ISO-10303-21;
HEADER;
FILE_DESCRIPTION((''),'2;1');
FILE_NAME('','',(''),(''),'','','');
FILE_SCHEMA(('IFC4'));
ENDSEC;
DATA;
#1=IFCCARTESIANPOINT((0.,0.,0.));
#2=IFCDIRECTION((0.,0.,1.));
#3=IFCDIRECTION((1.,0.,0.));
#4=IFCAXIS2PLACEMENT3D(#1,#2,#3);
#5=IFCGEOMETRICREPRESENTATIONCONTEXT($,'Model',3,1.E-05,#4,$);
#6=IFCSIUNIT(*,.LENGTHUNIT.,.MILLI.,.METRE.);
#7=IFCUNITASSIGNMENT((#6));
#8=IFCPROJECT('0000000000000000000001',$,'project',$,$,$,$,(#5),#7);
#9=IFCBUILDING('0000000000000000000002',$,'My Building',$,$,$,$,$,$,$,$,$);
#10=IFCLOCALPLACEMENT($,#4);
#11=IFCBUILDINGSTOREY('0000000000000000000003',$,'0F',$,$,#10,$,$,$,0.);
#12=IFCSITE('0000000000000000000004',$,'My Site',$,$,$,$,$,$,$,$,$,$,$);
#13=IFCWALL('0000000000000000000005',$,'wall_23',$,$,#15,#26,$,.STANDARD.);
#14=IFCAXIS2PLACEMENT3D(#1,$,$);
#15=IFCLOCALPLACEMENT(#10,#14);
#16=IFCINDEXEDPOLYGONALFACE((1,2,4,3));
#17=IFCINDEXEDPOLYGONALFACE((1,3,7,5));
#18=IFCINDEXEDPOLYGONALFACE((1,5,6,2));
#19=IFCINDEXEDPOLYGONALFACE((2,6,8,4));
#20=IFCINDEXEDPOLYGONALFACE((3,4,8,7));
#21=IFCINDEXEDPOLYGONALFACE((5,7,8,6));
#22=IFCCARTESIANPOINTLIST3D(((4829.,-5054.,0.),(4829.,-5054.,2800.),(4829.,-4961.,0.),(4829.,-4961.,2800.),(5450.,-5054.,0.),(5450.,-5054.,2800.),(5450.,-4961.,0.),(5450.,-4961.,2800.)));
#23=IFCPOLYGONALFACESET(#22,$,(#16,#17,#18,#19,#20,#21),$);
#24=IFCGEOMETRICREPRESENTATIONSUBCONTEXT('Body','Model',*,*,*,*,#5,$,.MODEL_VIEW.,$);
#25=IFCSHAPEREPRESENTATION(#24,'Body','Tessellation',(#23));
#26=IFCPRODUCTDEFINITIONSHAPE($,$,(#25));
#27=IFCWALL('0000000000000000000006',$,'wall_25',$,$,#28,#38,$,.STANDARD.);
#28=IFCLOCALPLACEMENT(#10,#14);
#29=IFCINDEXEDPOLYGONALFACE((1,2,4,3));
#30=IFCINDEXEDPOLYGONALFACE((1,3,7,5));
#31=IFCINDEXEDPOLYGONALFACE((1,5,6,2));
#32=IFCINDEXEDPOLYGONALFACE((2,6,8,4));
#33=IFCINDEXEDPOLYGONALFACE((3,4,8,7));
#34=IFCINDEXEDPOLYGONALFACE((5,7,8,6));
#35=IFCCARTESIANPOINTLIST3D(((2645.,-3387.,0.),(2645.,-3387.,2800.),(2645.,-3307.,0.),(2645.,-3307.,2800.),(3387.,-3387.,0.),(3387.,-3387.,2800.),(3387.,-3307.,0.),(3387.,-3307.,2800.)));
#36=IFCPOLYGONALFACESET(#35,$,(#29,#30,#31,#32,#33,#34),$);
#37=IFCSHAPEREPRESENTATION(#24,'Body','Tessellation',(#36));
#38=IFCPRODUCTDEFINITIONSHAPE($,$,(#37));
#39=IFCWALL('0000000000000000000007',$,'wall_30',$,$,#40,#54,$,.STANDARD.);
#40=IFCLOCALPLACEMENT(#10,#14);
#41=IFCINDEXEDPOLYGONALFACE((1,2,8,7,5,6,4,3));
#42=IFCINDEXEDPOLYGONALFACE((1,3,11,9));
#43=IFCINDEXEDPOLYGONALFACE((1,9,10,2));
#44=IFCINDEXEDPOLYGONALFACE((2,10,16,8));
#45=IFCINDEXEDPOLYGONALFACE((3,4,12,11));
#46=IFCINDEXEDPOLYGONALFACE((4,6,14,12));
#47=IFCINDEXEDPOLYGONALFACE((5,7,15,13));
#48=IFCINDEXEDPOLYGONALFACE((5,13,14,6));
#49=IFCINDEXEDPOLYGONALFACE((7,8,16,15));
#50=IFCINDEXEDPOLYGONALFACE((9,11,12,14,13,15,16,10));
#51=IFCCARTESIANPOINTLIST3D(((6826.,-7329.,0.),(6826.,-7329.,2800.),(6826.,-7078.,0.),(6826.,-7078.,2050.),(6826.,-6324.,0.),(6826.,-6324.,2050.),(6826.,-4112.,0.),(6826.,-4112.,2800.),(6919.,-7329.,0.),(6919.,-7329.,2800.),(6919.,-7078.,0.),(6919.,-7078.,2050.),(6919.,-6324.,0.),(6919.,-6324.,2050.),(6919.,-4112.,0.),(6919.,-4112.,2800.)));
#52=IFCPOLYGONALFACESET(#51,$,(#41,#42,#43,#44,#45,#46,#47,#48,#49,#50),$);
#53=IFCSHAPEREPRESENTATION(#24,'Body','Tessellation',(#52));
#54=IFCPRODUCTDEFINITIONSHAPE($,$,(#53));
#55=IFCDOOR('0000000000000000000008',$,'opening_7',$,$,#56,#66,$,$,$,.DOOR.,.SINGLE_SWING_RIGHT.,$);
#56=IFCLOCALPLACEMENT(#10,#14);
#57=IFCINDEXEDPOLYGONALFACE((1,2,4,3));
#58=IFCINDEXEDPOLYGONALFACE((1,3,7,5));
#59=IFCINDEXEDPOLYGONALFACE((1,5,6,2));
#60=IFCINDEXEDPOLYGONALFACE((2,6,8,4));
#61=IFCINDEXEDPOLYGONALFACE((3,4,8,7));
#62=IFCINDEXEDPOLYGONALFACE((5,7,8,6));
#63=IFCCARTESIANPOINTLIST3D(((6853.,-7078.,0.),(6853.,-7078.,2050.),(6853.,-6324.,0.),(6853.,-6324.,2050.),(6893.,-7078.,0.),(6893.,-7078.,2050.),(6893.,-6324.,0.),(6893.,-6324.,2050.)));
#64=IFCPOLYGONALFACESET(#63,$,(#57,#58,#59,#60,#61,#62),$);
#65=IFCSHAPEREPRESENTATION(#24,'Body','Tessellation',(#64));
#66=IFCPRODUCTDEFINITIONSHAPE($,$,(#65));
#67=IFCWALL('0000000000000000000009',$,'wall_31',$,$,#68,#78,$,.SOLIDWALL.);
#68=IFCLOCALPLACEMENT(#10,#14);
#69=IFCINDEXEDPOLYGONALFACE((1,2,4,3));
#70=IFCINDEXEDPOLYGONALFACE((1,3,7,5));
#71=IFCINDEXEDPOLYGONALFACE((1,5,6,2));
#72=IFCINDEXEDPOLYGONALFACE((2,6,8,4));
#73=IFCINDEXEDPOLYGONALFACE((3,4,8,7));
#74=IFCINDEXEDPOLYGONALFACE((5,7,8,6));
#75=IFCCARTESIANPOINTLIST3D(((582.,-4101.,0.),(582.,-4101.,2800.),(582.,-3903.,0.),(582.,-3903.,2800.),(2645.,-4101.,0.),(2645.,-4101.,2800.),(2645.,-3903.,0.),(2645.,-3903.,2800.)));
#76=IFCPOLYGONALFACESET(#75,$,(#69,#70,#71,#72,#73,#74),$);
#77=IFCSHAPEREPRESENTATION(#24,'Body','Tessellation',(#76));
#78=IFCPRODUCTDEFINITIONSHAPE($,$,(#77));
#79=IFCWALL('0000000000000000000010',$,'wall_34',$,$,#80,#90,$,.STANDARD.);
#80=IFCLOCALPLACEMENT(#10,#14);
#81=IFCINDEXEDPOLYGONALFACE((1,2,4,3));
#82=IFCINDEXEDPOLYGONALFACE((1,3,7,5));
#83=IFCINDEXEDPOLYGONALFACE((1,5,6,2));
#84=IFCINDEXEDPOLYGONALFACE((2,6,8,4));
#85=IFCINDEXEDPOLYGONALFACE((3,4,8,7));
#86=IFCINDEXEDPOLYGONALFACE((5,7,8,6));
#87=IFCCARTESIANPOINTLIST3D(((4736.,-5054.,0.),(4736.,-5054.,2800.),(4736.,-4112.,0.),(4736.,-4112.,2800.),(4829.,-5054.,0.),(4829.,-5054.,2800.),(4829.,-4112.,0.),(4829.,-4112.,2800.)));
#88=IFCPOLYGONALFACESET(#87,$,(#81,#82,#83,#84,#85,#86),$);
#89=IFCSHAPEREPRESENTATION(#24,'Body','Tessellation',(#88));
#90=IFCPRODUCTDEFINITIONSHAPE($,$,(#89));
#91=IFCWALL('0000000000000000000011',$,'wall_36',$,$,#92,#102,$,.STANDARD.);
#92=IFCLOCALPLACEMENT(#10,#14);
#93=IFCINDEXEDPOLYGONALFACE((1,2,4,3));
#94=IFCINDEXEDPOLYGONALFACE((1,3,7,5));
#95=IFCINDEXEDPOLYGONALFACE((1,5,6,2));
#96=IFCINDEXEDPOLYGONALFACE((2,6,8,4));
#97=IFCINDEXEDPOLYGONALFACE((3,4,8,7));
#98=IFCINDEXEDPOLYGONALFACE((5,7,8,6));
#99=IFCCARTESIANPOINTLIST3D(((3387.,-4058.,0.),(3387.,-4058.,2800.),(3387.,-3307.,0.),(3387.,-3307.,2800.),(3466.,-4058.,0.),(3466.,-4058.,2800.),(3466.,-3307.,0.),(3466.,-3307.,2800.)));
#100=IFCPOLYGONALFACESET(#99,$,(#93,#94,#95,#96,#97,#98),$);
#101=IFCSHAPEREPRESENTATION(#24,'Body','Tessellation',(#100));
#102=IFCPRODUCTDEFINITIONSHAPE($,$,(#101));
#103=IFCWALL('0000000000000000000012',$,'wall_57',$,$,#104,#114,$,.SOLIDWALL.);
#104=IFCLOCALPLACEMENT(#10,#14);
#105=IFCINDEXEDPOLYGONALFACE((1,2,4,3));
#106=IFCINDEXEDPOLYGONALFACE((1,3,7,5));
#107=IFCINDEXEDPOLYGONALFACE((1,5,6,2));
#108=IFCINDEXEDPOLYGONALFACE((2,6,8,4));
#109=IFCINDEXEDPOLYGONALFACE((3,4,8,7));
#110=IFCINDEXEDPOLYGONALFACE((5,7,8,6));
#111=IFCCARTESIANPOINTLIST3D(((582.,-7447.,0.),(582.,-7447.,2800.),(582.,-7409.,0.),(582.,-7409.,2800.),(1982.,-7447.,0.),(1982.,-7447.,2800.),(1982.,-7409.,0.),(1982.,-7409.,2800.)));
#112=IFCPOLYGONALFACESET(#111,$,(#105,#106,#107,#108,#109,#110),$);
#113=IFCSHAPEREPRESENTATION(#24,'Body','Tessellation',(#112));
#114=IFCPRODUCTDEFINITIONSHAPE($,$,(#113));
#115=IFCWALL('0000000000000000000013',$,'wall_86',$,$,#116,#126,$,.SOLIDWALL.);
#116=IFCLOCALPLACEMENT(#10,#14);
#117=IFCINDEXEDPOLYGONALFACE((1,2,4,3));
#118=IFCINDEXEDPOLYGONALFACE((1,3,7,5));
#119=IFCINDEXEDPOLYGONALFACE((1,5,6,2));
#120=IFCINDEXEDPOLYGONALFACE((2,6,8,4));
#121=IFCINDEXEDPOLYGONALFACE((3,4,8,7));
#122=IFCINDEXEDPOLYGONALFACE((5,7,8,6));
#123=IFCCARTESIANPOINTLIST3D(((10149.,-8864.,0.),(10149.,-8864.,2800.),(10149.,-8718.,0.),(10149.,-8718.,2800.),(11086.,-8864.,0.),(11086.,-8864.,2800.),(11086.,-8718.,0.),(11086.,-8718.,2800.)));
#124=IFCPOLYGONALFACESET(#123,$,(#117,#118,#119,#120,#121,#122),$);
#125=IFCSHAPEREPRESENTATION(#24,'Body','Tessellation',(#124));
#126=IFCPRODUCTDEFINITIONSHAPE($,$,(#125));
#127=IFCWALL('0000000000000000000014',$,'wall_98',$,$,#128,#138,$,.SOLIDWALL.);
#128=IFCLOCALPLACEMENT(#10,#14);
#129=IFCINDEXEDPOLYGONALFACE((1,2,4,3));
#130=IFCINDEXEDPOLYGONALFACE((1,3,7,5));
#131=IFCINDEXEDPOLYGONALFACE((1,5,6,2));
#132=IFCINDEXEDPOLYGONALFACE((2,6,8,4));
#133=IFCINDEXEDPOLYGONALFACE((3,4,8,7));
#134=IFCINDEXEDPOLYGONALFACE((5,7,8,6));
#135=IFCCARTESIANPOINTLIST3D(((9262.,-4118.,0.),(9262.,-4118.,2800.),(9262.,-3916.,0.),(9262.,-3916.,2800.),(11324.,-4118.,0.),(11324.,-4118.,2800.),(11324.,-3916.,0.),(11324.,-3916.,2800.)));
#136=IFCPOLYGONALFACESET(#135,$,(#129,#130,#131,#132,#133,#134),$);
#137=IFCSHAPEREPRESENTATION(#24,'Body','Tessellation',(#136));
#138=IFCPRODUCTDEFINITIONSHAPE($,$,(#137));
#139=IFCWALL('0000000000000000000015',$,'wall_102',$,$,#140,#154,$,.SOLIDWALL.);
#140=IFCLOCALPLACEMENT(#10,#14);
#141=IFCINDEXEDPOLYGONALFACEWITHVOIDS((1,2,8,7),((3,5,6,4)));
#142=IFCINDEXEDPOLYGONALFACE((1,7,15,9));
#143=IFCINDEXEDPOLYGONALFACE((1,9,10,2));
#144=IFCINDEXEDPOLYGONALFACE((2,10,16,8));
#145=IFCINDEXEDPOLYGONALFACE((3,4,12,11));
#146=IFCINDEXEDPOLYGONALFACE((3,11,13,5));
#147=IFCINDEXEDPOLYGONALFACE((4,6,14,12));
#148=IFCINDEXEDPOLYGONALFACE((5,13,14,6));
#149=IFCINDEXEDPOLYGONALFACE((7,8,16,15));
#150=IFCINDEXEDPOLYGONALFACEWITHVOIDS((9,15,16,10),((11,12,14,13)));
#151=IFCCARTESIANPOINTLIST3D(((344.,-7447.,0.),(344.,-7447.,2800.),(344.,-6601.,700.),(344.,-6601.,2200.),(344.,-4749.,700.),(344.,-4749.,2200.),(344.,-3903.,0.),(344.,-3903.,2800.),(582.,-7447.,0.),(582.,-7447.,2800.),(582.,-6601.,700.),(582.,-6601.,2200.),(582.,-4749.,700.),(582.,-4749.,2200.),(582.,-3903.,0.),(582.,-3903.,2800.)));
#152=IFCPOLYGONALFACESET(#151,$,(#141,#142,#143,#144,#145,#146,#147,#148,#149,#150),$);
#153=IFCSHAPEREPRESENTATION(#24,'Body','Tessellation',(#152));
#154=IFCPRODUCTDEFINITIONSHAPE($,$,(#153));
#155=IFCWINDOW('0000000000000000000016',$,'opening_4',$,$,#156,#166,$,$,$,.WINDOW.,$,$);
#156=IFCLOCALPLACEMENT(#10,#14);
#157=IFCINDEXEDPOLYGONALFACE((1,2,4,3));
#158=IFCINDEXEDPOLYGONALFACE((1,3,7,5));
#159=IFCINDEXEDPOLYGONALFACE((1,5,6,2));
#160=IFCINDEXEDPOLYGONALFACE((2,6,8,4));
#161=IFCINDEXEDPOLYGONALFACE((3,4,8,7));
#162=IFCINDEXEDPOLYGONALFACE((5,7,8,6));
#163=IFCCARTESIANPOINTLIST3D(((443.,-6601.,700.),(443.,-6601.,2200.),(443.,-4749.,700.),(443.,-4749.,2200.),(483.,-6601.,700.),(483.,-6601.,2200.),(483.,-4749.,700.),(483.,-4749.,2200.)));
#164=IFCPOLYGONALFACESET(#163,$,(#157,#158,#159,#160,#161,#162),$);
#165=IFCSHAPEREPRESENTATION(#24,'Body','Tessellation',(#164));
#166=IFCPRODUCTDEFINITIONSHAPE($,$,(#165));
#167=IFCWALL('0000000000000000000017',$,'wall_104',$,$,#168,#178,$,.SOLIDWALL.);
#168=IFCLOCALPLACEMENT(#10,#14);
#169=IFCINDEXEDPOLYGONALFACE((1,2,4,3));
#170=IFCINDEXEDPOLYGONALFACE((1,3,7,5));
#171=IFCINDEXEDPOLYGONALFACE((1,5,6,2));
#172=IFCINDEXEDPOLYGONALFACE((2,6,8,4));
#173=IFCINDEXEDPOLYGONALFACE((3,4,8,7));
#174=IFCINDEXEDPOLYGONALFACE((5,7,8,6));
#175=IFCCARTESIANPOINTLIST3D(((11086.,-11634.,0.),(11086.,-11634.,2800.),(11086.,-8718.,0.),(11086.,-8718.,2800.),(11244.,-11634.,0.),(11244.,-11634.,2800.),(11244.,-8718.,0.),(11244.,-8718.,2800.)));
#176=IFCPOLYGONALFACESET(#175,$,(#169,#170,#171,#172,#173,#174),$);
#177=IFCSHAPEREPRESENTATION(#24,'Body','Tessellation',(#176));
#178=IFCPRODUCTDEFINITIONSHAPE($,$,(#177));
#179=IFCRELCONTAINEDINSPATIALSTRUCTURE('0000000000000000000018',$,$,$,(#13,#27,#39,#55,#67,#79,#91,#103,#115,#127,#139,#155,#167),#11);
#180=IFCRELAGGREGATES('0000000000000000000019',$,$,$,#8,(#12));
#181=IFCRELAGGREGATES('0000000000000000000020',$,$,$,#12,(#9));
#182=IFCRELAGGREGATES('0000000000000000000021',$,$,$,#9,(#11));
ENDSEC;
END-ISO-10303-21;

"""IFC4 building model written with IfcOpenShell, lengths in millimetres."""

from ifc_helpers import new_model, si_unit, frame, origin_with_axes, place, context, subcontext, project, spatial, indexed_curve, outline, extrude, element, fill, save


model = new_model("IFC4")

# Units and contexts
model_context = context("Model", 3, precision=1e-05, world=origin_with_axes())
body_context = subcontext(model_context, "Body", "Model", "MODEL_VIEW")
ifc_project = project(units=[si_unit("LENGTHUNIT", "METRE", prefix="MILLI")], contexts=[model_context])

# Site, building, storey
site = spatial("IfcSite", under=ifc_project, Name="My Site")
building = spatial("IfcBuilding", under=site, Name="My Building")
storey_placement = place(None, origin_with_axes())
storey = spatial("IfcBuildingStorey", under=building, at=storey_placement, Name="0F", Elevation=0.0)

# Walls
wall_1_placement = place(storey_placement, origin_with_axes())
element("IfcWall", 1, at=wall_1_placement, inside=storey, Name="wall_23", PredefinedType="STANDARD", context=body_context, shape_type="SweptSolid", body=[
    extrude(outline(indexed_curve([(4829.0, -5054.0), (5450.0, -5054.0), (5450.0, -4961.0), (4829.0, -4961.0), (4829.0, -5054.0)])), None, (0.0, 0.0, 1.0), 2800.0),
])
wall_2_placement = place(storey_placement, origin_with_axes())
element("IfcWall", 2, at=wall_2_placement, inside=storey, Name="wall_25", PredefinedType="STANDARD", context=body_context, shape_type="SweptSolid", body=[
    extrude(outline(indexed_curve([(2645.0, -3387.0), (3387.0, -3387.0), (3387.0, -3307.0), (2645.0, -3307.0), (2645.0, -3387.0)])), None, (0.0, 0.0, 1.0), 2800.0),
])

# Wall, opening, door
wall_3_placement = place(storey_placement, origin_with_axes())
wall_3 = element("IfcWall", 3, at=wall_3_placement, inside=storey, Name="wall_30", PredefinedType="STANDARD", context=body_context, shape_type="SweptSolid", body=[
    extrude(outline(indexed_curve([(6826.0, -4112.0), (6826.0, -7329.0), (6919.0, -7329.0), (6919.0, -4112.0), (6826.0, -4112.0)])), None, (0.0, 0.0, 1.0), 2800.0),
])
opening_1_placement = place(wall_3_placement, origin_with_axes())
opening_1 = element("IfcOpeningElement", 4, at=opening_1_placement, cuts=wall_3, ObjectType="Opening", context=body_context, shape_type="SweptSolid", body=[
    extrude(outline(indexed_curve([(6760.0, -7078.0), (6985.0, -7078.0), (6985.0, -6324.0), (6760.0, -6324.0), (6760.0, -7078.0)])), None, (0.0, 0.0, 1.0), 2050.0),
])
door_1_placement = place(opening_1_placement, origin_with_axes())
door_1 = element("IfcDoor", 5, at=door_1_placement, inside=storey, Name="opening_7", OperationType="SINGLE_SWING_RIGHT", PredefinedType="DOOR", context=body_context, shape_type="SweptSolid", body=[
    extrude(outline(indexed_curve([(6853.0, -7078.0), (6893.0, -7078.0), (6893.0, -6324.0), (6853.0, -6324.0), (6853.0, -7078.0)])), None, (0.0, 0.0, 1.0), 2050.0),
])
fill(opening_1, door_1)

# Walls
wall_4_placement = place(storey_placement, origin_with_axes())
element("IfcWall", 6, at=wall_4_placement, inside=storey, Name="wall_31", PredefinedType="SOLIDWALL", context=body_context, shape_type="SweptSolid", body=[
    extrude(outline(indexed_curve([(582.0, -4101.0), (2645.0, -4101.0), (2645.0, -3903.0), (582.0, -3903.0), (582.0, -4101.0)])), None, (0.0, 0.0, 1.0), 2800.0),
])
wall_5_placement = place(storey_placement, origin_with_axes())
element("IfcWall", 7, at=wall_5_placement, inside=storey, Name="wall_34", PredefinedType="STANDARD", context=body_context, shape_type="SweptSolid", body=[
    extrude(outline(indexed_curve([(4736.0, -4112.0), (4736.0, -5054.0), (4829.0, -5054.0), (4829.0, -4112.0), (4736.0, -4112.0)])), None, (0.0, 0.0, 1.0), 2800.0),
])
wall_6_placement = place(storey_placement, origin_with_axes())
element("IfcWall", 8, at=wall_6_placement, inside=storey, Name="wall_36", PredefinedType="STANDARD", context=body_context, shape_type="SweptSolid", body=[
    extrude(outline(indexed_curve([(3387.0, -3307.0), (3387.0, -4058.0), (3466.0, -4058.0), (3466.0, -3307.0), (3387.0, -3307.0)])), None, (0.0, 0.0, 1.0), 2800.0),
])
wall_7_placement = place(storey_placement, origin_with_axes())
element("IfcWall", 9, at=wall_7_placement, inside=storey, Name="wall_57", PredefinedType="SOLIDWALL", context=body_context, shape_type="SweptSolid", body=[
    extrude(outline(indexed_curve([(582.0, -7447.0), (1982.0, -7447.0), (1982.0, -7409.0), (582.0, -7409.0), (582.0, -7447.0)])), None, (0.0, 0.0, 1.0), 2800.0),
])
wall_8_placement = place(storey_placement, origin_with_axes())
element("IfcWall", 10, at=wall_8_placement, inside=storey, Name="wall_86", PredefinedType="SOLIDWALL", context=body_context, shape_type="SweptSolid", body=[
    extrude(outline(indexed_curve([(10149.0, -8864.0), (11086.0, -8864.0), (11086.0, -8718.0), (10149.0, -8718.0), (10149.0, -8864.0)])), None, (0.0, 0.0, 1.0), 2800.0),
])
wall_9_placement = place(storey_placement, origin_with_axes())
element("IfcWall", 11, at=wall_9_placement, inside=storey, Name="wall_98", PredefinedType="SOLIDWALL", context=body_context, shape_type="SweptSolid", body=[
    extrude(outline(indexed_curve([(9262.0, -4118.0), (11324.0, -4118.0), (11324.0, -3916.0), (9262.0, -3916.0), (9262.0, -4118.0)])), None, (0.0, 0.0, 1.0), 2800.0),
])

# Wall, opening, window
wall_10_placement = place(storey_placement, origin_with_axes())
wall_10 = element("IfcWall", 12, at=wall_10_placement, inside=storey, Name="wall_102", PredefinedType="SOLIDWALL", context=body_context, shape_type="SweptSolid", body=[
    extrude(outline(indexed_curve([(344.0, -3903.0), (344.0, -7447.0), (582.0, -7447.0), (582.0, -3903.0), (344.0, -3903.0)])), None, (0.0, 0.0, 1.0), 2800.0),
])
opening_2_placement = place(wall_10_placement, origin_with_axes())
opening_2 = element("IfcOpeningElement", 13, at=opening_2_placement, cuts=wall_10, ObjectType="Opening", context=body_context, shape_type="SweptSolid", body=[
    extrude(outline(indexed_curve([(278.0, -6601.0), (648.0, -6601.0), (648.0, -4749.0), (278.0, -4749.0), (278.0, -6601.0)])), frame((0.0, 0.0, 700.0), z_axis=(0.0, 0.0, 1.0), x_axis=(1.0, 0.0, 0.0)), (0.0, 0.0, 1.0), 1500.0),
])
window_placement = place(opening_2_placement, origin_with_axes())
window = element("IfcWindow", 14, at=window_placement, inside=storey, Name="opening_4", PredefinedType="WINDOW", context=body_context, shape_type="SweptSolid", body=[
    extrude(outline(indexed_curve([(443.0, -6601.0), (483.0, -6601.0), (483.0, -4749.0), (443.0, -4749.0), (443.0, -6601.0)])), frame((0.0, 0.0, 700.0), z_axis=(0.0, 0.0, 1.0), x_axis=(1.0, 0.0, 0.0)), (0.0, 0.0, 1.0), 1500.0),
])
fill(opening_2, window)

# Wall
wall_11_placement = place(storey_placement, origin_with_axes())
element("IfcWall", 15, at=wall_11_placement, inside=storey, Name="wall_104", PredefinedType="SOLIDWALL", context=body_context, shape_type="SweptSolid", body=[
    extrude(outline(indexed_curve([(11086.0, -8718.0), (11086.0, -11634.0), (11244.0, -11634.0), (11244.0, -8718.0), (11086.0, -8718.0)])), None, (0.0, 0.0, 1.0), 2800.0),
])

save(model, "model.ifc")
